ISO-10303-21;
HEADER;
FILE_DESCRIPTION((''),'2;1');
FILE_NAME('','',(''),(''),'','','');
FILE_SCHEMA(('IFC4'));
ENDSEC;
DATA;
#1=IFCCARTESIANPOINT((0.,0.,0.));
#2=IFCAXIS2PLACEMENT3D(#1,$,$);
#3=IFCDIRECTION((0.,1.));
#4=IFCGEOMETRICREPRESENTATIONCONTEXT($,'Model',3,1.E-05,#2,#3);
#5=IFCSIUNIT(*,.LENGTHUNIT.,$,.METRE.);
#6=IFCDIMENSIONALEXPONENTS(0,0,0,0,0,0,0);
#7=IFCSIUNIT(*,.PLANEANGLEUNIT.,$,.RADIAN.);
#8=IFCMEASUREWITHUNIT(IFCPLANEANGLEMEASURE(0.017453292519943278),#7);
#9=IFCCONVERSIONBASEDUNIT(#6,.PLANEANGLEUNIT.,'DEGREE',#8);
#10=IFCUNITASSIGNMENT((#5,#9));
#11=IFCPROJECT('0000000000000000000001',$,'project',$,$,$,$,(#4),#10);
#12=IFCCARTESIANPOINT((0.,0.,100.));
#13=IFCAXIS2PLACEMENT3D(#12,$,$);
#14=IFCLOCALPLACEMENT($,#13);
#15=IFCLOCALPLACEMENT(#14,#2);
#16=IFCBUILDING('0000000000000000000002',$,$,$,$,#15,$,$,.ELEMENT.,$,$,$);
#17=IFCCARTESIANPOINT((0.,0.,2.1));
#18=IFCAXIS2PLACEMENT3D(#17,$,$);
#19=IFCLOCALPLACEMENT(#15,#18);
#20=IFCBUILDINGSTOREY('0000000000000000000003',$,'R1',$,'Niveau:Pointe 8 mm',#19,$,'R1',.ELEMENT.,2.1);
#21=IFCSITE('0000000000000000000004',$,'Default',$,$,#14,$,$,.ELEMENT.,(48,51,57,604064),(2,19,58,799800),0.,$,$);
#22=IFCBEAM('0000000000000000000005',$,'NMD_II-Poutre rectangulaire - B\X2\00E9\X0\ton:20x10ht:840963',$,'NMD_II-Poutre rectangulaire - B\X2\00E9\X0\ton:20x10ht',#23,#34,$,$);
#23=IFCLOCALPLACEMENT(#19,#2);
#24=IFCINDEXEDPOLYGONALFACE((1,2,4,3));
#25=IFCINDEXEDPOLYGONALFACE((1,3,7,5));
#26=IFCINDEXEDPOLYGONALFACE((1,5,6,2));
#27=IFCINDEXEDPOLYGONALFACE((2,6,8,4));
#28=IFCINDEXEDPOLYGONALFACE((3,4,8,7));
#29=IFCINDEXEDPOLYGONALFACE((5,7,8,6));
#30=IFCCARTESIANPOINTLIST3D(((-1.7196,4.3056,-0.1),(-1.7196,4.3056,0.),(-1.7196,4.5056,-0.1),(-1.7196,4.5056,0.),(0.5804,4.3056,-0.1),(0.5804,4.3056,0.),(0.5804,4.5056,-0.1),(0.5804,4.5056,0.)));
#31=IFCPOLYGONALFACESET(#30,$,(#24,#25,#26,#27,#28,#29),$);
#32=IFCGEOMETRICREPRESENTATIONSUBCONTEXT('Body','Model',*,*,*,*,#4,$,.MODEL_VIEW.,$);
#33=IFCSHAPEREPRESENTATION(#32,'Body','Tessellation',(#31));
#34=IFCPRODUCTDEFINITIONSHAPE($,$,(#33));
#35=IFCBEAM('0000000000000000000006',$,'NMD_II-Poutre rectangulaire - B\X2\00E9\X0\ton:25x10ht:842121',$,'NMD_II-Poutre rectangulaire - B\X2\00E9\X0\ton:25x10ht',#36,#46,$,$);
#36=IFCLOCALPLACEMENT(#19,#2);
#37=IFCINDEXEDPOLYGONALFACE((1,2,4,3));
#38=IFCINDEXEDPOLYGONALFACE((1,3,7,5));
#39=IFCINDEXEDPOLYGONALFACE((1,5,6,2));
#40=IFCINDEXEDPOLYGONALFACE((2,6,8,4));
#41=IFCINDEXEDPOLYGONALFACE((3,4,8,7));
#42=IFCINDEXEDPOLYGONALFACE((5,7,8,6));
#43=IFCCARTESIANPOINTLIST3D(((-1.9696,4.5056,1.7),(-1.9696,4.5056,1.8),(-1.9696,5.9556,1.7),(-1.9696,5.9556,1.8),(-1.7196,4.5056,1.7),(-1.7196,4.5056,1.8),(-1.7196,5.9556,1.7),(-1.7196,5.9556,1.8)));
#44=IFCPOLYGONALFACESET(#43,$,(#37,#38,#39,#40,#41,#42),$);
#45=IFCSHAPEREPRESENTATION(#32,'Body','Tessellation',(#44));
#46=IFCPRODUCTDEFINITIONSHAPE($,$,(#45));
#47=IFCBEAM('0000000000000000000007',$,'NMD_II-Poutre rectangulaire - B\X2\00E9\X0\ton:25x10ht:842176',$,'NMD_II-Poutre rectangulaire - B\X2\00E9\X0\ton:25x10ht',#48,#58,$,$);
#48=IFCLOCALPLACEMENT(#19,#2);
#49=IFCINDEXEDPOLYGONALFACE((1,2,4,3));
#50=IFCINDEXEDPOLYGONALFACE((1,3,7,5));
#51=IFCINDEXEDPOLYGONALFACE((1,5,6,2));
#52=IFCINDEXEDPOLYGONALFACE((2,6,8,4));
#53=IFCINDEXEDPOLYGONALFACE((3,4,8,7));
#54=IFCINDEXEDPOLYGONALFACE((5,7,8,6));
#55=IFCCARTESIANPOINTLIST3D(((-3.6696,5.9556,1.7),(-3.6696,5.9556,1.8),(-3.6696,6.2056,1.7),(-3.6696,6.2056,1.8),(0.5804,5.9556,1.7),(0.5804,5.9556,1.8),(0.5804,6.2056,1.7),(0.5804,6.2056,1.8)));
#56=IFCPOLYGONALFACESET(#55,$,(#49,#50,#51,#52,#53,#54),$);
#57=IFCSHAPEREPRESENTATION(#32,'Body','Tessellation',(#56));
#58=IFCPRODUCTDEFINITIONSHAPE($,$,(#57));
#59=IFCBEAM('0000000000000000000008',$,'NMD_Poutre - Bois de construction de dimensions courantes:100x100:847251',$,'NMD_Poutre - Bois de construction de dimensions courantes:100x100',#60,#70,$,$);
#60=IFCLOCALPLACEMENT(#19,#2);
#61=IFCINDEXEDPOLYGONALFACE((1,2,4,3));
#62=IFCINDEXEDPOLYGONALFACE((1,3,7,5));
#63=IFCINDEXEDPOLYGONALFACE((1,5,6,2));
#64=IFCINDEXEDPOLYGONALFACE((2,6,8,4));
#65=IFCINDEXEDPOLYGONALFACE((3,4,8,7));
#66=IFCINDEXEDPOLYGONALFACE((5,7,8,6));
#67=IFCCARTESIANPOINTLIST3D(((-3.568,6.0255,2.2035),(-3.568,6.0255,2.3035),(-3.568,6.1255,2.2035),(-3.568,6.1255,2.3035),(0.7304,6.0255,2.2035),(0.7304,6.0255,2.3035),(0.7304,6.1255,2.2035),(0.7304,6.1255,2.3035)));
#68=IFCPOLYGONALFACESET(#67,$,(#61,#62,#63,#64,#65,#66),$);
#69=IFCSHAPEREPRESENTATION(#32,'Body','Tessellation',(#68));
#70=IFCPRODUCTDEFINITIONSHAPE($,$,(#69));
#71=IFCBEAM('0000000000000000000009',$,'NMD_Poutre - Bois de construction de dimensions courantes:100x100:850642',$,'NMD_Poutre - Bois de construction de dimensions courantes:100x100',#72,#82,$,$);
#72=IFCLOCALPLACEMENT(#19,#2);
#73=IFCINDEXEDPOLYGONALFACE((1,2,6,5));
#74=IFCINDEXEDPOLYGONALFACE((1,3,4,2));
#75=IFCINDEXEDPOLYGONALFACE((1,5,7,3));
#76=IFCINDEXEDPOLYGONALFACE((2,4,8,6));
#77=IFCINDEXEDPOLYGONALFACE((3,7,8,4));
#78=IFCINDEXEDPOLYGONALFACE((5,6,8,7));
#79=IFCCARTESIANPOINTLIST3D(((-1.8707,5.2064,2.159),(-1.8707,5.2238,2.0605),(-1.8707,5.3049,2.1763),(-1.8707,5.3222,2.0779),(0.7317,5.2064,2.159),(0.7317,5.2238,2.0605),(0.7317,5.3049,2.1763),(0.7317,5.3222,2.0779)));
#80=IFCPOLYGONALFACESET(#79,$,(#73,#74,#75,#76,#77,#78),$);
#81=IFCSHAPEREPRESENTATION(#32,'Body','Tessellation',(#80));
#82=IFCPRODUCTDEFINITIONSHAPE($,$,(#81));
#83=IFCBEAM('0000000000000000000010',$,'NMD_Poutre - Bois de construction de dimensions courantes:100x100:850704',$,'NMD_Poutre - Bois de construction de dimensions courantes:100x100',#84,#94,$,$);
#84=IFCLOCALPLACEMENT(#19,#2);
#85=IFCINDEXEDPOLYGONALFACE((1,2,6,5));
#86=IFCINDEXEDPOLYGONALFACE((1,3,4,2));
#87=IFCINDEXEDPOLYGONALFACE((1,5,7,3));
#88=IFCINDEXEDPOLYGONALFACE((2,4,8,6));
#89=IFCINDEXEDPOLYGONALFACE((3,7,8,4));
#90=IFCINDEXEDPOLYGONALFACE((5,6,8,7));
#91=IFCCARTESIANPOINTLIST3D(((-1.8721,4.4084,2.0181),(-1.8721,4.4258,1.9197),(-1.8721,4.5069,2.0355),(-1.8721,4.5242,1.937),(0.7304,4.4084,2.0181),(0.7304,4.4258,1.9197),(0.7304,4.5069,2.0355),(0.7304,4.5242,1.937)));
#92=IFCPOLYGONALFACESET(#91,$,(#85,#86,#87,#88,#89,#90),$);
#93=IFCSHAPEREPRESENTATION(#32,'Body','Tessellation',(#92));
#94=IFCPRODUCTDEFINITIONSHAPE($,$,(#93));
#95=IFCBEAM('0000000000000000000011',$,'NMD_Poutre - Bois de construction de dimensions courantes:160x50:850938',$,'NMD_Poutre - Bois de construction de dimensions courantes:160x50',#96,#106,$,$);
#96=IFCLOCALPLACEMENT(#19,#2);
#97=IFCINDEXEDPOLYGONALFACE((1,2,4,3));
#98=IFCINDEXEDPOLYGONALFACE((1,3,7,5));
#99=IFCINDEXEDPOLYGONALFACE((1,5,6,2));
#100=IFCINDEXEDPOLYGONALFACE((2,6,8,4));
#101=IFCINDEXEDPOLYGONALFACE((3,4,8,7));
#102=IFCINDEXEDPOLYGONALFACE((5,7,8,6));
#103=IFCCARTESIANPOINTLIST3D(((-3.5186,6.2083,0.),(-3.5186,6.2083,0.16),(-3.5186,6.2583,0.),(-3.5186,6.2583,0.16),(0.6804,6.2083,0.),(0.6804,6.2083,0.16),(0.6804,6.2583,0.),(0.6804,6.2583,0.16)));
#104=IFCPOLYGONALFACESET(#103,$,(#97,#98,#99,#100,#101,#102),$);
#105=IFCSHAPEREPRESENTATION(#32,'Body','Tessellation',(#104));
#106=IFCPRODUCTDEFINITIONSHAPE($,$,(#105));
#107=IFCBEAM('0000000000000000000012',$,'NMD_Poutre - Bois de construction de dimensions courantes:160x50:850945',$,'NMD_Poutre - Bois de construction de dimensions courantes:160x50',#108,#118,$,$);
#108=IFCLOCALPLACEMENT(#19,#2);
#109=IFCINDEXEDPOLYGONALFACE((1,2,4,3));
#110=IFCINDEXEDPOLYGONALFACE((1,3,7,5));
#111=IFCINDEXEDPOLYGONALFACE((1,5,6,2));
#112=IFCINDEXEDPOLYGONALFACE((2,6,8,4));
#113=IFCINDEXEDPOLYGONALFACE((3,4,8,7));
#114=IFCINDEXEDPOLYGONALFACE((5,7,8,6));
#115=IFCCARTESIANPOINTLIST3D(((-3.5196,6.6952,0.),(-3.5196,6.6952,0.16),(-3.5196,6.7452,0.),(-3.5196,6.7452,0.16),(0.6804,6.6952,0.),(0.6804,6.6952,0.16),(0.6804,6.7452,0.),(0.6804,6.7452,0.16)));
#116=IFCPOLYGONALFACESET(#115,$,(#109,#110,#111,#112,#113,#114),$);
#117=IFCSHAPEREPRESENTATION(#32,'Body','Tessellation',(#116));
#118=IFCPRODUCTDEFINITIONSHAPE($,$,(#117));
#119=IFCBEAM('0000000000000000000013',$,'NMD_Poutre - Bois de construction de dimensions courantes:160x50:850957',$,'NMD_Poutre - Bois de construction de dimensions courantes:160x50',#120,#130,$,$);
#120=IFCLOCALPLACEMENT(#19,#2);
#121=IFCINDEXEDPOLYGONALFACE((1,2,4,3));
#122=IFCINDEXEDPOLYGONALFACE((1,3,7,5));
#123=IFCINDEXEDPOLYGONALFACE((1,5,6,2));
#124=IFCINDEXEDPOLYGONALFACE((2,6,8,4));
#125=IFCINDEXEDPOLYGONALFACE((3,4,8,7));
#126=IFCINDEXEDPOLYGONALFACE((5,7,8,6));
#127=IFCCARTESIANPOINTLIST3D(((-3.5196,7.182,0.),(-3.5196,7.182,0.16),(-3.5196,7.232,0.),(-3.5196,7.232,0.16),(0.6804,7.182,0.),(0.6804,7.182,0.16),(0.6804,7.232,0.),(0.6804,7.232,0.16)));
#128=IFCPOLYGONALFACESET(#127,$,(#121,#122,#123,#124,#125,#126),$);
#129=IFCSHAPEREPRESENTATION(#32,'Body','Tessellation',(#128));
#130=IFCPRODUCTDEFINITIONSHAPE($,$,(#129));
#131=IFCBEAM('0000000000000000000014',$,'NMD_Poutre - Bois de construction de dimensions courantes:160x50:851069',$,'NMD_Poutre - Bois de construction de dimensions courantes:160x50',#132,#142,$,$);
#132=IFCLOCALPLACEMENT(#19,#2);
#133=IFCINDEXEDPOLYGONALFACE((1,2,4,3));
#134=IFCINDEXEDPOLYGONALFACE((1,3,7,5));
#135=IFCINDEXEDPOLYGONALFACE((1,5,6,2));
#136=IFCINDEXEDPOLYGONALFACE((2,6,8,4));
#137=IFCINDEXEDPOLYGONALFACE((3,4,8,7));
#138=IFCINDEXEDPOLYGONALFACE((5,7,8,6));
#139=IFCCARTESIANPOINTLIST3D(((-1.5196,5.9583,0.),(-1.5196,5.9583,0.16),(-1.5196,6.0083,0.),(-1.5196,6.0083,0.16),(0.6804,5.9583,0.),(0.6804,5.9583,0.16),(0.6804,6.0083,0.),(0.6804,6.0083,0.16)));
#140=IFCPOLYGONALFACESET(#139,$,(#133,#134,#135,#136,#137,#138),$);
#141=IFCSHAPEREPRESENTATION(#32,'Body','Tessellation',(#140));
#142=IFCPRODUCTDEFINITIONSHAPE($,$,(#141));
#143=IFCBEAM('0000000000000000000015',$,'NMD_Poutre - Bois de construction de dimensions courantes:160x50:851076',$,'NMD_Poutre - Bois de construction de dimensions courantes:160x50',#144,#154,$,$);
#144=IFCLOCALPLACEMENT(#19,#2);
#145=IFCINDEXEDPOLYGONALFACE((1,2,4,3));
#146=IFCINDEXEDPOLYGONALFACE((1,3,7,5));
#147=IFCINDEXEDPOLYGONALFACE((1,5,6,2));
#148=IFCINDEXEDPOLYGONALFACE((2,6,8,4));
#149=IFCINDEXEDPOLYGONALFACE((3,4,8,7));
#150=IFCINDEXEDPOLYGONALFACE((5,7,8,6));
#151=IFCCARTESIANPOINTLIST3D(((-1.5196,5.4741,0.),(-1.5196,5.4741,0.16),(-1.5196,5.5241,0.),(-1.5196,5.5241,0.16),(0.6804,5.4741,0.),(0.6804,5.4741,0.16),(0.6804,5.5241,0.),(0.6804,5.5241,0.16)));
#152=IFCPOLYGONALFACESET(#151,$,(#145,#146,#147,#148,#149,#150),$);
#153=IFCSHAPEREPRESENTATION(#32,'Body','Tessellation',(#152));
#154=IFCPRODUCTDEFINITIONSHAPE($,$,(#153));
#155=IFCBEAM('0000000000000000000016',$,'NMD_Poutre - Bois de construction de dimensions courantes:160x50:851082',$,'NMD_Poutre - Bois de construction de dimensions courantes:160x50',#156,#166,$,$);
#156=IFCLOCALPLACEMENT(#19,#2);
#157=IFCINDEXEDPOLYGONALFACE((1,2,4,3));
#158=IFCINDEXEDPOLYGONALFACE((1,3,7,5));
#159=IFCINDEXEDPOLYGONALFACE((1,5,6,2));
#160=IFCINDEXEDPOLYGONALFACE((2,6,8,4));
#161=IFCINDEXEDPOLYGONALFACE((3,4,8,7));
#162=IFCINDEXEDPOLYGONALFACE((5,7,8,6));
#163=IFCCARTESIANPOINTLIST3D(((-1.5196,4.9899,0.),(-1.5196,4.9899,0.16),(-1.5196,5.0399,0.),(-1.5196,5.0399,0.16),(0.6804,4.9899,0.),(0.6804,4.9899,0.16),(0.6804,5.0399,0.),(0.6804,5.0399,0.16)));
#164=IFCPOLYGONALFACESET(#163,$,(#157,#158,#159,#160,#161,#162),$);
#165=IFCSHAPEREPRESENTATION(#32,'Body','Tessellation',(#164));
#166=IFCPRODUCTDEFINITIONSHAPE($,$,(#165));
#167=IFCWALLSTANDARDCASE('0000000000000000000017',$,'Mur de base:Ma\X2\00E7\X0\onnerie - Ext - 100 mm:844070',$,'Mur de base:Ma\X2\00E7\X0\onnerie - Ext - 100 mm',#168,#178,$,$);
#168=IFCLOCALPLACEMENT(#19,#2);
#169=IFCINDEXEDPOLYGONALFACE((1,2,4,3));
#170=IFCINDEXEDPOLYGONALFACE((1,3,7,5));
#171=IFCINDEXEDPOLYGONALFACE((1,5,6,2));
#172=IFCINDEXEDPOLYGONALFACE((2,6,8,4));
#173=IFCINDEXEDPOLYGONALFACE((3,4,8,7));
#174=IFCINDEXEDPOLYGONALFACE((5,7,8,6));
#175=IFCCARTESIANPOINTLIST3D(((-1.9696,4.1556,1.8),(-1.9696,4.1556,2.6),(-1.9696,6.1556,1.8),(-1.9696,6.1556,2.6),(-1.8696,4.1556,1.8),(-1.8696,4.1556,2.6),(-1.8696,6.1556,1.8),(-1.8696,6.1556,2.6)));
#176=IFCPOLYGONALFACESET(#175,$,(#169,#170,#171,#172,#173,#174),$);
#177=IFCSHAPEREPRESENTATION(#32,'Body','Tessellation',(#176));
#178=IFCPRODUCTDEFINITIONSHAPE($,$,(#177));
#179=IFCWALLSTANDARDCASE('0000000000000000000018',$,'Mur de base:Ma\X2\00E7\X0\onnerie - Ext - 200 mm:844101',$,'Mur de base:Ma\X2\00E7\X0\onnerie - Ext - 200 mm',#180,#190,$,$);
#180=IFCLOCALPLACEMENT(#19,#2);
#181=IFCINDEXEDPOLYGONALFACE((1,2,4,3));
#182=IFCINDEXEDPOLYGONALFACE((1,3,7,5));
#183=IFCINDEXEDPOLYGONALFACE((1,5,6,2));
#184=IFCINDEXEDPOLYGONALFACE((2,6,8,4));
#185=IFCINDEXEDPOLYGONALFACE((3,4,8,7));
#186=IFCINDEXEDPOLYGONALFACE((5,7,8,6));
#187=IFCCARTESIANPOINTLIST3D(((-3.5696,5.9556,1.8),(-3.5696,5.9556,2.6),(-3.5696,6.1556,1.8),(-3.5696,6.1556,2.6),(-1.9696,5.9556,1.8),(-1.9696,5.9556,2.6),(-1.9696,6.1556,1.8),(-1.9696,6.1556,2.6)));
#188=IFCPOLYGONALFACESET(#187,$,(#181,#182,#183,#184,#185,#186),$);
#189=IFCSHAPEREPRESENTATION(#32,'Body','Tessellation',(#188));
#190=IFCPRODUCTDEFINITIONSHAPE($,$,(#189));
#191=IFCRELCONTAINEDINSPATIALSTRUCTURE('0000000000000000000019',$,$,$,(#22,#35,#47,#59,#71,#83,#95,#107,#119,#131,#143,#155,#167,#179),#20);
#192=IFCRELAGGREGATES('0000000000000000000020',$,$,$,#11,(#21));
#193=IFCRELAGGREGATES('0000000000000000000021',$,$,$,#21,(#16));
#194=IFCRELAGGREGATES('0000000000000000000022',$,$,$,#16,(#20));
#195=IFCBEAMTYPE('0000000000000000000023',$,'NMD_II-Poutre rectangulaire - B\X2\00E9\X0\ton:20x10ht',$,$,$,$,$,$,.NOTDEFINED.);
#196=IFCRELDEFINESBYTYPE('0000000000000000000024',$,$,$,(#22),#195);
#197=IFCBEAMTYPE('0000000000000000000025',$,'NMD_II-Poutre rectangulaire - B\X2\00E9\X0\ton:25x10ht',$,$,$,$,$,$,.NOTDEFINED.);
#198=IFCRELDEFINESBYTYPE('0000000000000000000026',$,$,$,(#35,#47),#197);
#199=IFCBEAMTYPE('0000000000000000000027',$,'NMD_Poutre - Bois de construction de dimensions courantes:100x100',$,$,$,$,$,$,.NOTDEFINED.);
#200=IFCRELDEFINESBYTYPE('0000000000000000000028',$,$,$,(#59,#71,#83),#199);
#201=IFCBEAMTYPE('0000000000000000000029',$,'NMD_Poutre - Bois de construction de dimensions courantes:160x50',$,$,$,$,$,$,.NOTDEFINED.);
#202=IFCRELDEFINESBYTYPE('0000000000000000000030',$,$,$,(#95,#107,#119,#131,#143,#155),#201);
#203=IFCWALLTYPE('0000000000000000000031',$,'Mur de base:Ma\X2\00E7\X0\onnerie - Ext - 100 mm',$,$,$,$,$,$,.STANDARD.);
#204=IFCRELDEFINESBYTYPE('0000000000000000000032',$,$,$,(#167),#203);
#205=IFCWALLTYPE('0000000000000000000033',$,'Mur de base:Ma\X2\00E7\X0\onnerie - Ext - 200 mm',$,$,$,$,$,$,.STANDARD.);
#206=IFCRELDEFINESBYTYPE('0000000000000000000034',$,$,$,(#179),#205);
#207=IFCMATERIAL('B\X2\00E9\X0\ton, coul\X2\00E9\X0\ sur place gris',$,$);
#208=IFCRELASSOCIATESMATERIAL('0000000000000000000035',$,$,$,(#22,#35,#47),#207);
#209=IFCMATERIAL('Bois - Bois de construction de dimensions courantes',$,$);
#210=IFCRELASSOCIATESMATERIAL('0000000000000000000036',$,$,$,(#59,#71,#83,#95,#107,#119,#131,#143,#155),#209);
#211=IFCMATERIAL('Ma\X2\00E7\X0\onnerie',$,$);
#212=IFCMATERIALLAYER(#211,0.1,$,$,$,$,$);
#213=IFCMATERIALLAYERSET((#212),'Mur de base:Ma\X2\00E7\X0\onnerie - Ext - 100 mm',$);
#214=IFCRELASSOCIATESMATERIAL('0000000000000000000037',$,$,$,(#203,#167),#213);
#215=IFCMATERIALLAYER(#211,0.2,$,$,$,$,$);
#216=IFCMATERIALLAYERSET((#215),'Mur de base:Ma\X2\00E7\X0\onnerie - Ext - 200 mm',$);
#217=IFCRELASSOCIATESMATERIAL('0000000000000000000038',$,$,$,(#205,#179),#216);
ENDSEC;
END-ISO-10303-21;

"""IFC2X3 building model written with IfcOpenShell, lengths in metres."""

from ifc_helpers import new_model, entity, si_unit, converted_unit, direction, frame, frame_2d, origin, place, context, subcontext, project, spatial, rectangle, extrude, material, layer, layer_set, layer_usage, type_object, element, save


model = new_model("IFC2X3")

# Units and contexts
model_context = context("Model", 3, precision=1e-05, world=origin(), true_north=direction((0.0, 1.0)))
body_context = subcontext(model_context, "Body", "Model", "MODEL_VIEW")
ifc_project = project(units=[si_unit("LENGTHUNIT", "METRE"), converted_unit("PLANEANGLEUNIT", "DEGREE", entity("IfcPlaneAngleMeasure", 0.017453292519943278), si_unit("PLANEANGLEUNIT", "RADIAN"), dimensions=[0, 0, 0, 0, 0, 0, 0])], contexts=[model_context])

# Site, building, storey
site_placement = place(None, frame((0.0, 0.0, 100.0)))
site = spatial("IfcSite", under=ifc_project, at=site_placement, Name="Default", CompositionType="ELEMENT", RefLatitude=(48, 51, 57, 604064), RefLongitude=(2, 19, 58, 799800), RefElevation=0.0)
building_placement = place(site_placement, origin())
building = spatial("IfcBuilding", under=site, at=building_placement, CompositionType="ELEMENT")
storey_placement = place(building_placement, frame((0.0, 0.0, 2.1)))
storey = spatial("IfcBuildingStorey", under=building, at=storey_placement, Name="R1", ObjectType="Niveau:Pointe 8 mm", LongName="R1", CompositionType="ELEMENT", Elevation=2.1)

# Beams
ifc_material_1 = material(Name="Béton, coulé sur place gris")
beam_type_1 = type_object("IfcBeamType", Name="NMD_II-Poutre rectangulaire - Béton:20x10ht", PredefinedType="NOTDEFINED")
beam_1_placement = place(storey_placement, frame((0.5804, 4.4056, 0.0), z_axis=(0.0, 0.0, 1.0), x_axis=(-1.0, 0.0, 0.0)))
element("IfcBeam", 1, at=beam_1_placement, inside=storey, type_object=beam_type_1, material=ifc_material_1, Name="NMD_II-Poutre rectangulaire - Béton:20x10ht:840963", ObjectType="NMD_II-Poutre rectangulaire - Béton:20x10ht", context=body_context, shape_type="SweptSolid", body=[
    extrude(rectangle(XDim=0.1, YDim=0.2, at=frame_2d((0.0, 0.0), x_axis=(1.0, 0.0))), frame((0.0, 0.0, -0.05), z_axis=(1.0, 0.0, 0.0), x_axis=(0.0, 0.0, -1.0)), (0.0, 0.0, 1.0), 2.3),
])
beam_type_2 = type_object("IfcBeamType", Name="NMD_II-Poutre rectangulaire - Béton:25x10ht", PredefinedType="NOTDEFINED")
beam_2_placement = place(storey_placement, frame((-1.8446, 6.0806, 1.8), z_axis=(0.0, 0.0, 1.0), x_axis=(0.0, -1.0, 0.0)))
element("IfcBeam", 2, at=beam_2_placement, inside=storey, type_object=beam_type_2, material=ifc_material_1, Name="NMD_II-Poutre rectangulaire - Béton:25x10ht:842121", ObjectType="NMD_II-Poutre rectangulaire - Béton:25x10ht", context=body_context, shape_type="SweptSolid", body=[
    extrude(rectangle(XDim=0.1, YDim=0.25, at=frame_2d((0.0, 0.0), x_axis=(1.0, 0.0))), frame((0.125, 0.0, -0.05), z_axis=(1.0, 0.0, 0.0), x_axis=(0.0, 0.0, -1.0)), (0.0, 0.0, 1.0), 1.45),
])
beam_3_placement = place(storey_placement, frame((0.7054, 6.0806, 1.8), z_axis=(0.0, 0.0, 1.0), x_axis=(-1.0, 0.0, 0.0)))
element("IfcBeam", 3, at=beam_3_placement, inside=storey, type_object=beam_type_2, material=ifc_material_1, Name="NMD_II-Poutre rectangulaire - Béton:25x10ht:842176", ObjectType="NMD_II-Poutre rectangulaire - Béton:25x10ht", context=body_context, shape_type="SweptSolid", body=[
    extrude(rectangle(XDim=0.1, YDim=0.25, at=frame_2d((0.0, 0.0), x_axis=(1.0, 0.0))), frame((0.125, 0.0, -0.05), z_axis=(1.0, 0.0, 0.0), x_axis=(0.0, 0.0, -1.0)), (0.0, 0.0, 1.0), 4.25),
])
ifc_material_2 = material(Name="Bois - Bois de construction de dimensions courantes")
beam_type_3 = type_object("IfcBeamType", Name="NMD_Poutre - Bois de construction de dimensions courantes:100x100", PredefinedType="NOTDEFINED")
beam_4_placement = place(storey_placement, frame((-3.5685, 6.0755, 2.3035)))
element("IfcBeam", 4, at=beam_4_placement, inside=storey, type_object=beam_type_3, material=ifc_material_2, Name="NMD_Poutre - Bois de construction de dimensions courantes:100x100:847251", ObjectType="NMD_Poutre - Bois de construction de dimensions courantes:100x100", context=body_context, shape_type="SweptSolid", body=[
    extrude(rectangle(XDim=0.1, YDim=0.1, at=frame_2d((0.0, 0.0), x_axis=(1.0, 0.0))), frame((0.0004, 0.0, -0.05), z_axis=(1.0, 0.0, 0.0), x_axis=(0.0, 0.0, -1.0)), (0.0, 0.0, 1.0), 4.2984),
])
beam_5_placement = place(storey_placement, frame((-1.9196, 5.2556, 2.1676)))
element("IfcBeam", 5, at=beam_5_placement, inside=storey, type_object=beam_type_3, material=ifc_material_2, Name="NMD_Poutre - Bois de construction de dimensions courantes:100x100:850642", ObjectType="NMD_Poutre - Bois de construction de dimensions courantes:100x100", context=body_context, shape_type="SweptSolid", body=[
    extrude(rectangle(XDim=0.1, YDim=0.1, at=frame_2d((0.0, 0.0), x_axis=(0.0, 1.0))), frame((0.0489, 0.0087, -0.0492), z_axis=(1.0, 0.0, 0.0), x_axis=(0.0, -0.984777, -0.17382)), (0.0, 0.0, 1.0), 2.6024),
])
beam_6_placement = place(storey_placement, frame((-1.8196, 4.4576, 2.0268)))
element("IfcBeam", 6, at=beam_6_placement, inside=storey, type_object=beam_type_3, material=ifc_material_2, Name="NMD_Poutre - Bois de construction de dimensions courantes:100x100:850704", ObjectType="NMD_Poutre - Bois de construction de dimensions courantes:100x100", context=body_context, shape_type="SweptSolid", body=[
    extrude(rectangle(XDim=0.1, YDim=0.1, at=frame_2d((0.0, 0.0), x_axis=(0.0, 1.0))), frame((-0.0525, 0.0087, -0.0492), z_axis=(1.0, 0.0, 0.0), x_axis=(0.0, -0.984777, -0.17382)), (0.0, 0.0, 1.0), 2.6025),
])
beam_type_4 = type_object("IfcBeamType", Name="NMD_Poutre - Bois de construction de dimensions courantes:160x50", PredefinedType="NOTDEFINED")
beam_7_placement = place(storey_placement, frame((-3.5196, 6.2333, 0.16)))
element("IfcBeam", 7, at=beam_7_placement, inside=storey, type_object=beam_type_4, material=ifc_material_2, Name="NMD_Poutre - Bois de construction de dimensions courantes:160x50:850938", ObjectType="NMD_Poutre - Bois de construction de dimensions courantes:160x50", context=body_context, shape_type="SweptSolid", body=[
    extrude(rectangle(XDim=0.16, YDim=0.05, at=frame_2d((0.0, 0.0), x_axis=(1.0, 0.0))), frame((0.001, 0.0, -0.08), z_axis=(1.0, 0.0, 0.0), x_axis=(0.0, 0.0, -1.0)), (0.0, 0.0, 1.0), 4.199),
])
for number, where, name in (
    (8, (-3.5196, 6.7202, 0.16), "NMD_Poutre - Bois de construction de dimensions courantes:160x50:850945"),
    (9, (-3.5196, 7.207, 0.16), "NMD_Poutre - Bois de construction de dimensions courantes:160x50:850957"),
):
    element("IfcBeam", number, at=place(storey_placement, frame(where)), inside=storey, type_object=beam_type_4, material=ifc_material_2, Name=name, ObjectType="NMD_Poutre - Bois de construction de dimensions courantes:160x50", context=body_context, shape_type="SweptSolid", body=[
        extrude(rectangle(XDim=0.16, YDim=0.05, at=frame_2d((0.0, 0.0), x_axis=(1.0, 0.0))), frame((0.0, 0.0, -0.08), z_axis=(1.0, 0.0, 0.0), x_axis=(0.0, 0.0, -1.0)), (0.0, 0.0, 1.0), 4.2),
    ])
for number, where, name in (
    (10, (-1.5196, 5.9833, 0.16), "NMD_Poutre - Bois de construction de dimensions courantes:160x50:851069"),
    (11, (-1.5196, 5.4991, 0.16), "NMD_Poutre - Bois de construction de dimensions courantes:160x50:851076"),
    (12, (-1.5196, 5.0149, 0.16), "NMD_Poutre - Bois de construction de dimensions courantes:160x50:851082"),
):
    element("IfcBeam", number, at=place(storey_placement, frame(where)), inside=storey, type_object=beam_type_4, material=ifc_material_2, Name=name, ObjectType="NMD_Poutre - Bois de construction de dimensions courantes:160x50", context=body_context, shape_type="SweptSolid", body=[
        extrude(rectangle(XDim=0.16, YDim=0.05, at=frame_2d((0.0, 0.0), x_axis=(1.0, 0.0))), frame((0.0, 0.0, -0.08), z_axis=(1.0, 0.0, 0.0), x_axis=(0.0, 0.0, -1.0)), (0.0, 0.0, 1.0), 2.2),
    ])

# Walls
ifc_material_3 = material(Name="Maçonnerie")
ifc_layer_1 = layer(ifc_material_3, 0.1)
ifc_layer_set_1 = layer_set([ifc_layer_1], Name="Mur de base:Maçonnerie - Ext - 100 mm")
ifc_layer_usage_1 = layer_usage(ifc_layer_set_1, "AXIS2", "NEGATIVE", 0.05)
wall_type_1 = type_object("IfcWallType", Name="Mur de base:Maçonnerie - Ext - 100 mm", PredefinedType="STANDARD", material=ifc_layer_set_1)
wall_1_placement = place(storey_placement, frame((-1.9196, 6.1556, 1.8), z_axis=(0.0, 0.0, 1.0), x_axis=(0.0, -1.0, 0.0)))
element("IfcWallStandardCase", 13, at=wall_1_placement, inside=storey, type_object=wall_type_1, material=ifc_layer_usage_1, Name="Mur de base:Maçonnerie - Ext - 100 mm:844070", ObjectType="Mur de base:Maçonnerie - Ext - 100 mm", context=body_context, shape_type="SweptSolid", body=[
    extrude(rectangle(XDim=2.0, YDim=0.1, at=frame_2d((1.0, 0.0), x_axis=(-1.0, 0.0))), origin(), (0.0, 0.0, 1.0), 0.8),
])
ifc_layer_2 = layer(ifc_material_3, 0.2)
ifc_layer_set_2 = layer_set([ifc_layer_2], Name="Mur de base:Maçonnerie - Ext - 200 mm")
ifc_layer_usage_2 = layer_usage(ifc_layer_set_2, "AXIS2", "NEGATIVE", 0.1)
wall_type_2 = type_object("IfcWallType", Name="Mur de base:Maçonnerie - Ext - 200 mm", PredefinedType="STANDARD", material=ifc_layer_set_2)
wall_2_placement = place(storey_placement, frame((-3.5696, 6.0556, 1.8)))
element("IfcWallStandardCase", 14, at=wall_2_placement, inside=storey, type_object=wall_type_2, material=ifc_layer_usage_2, Name="Mur de base:Maçonnerie - Ext - 200 mm:844101", ObjectType="Mur de base:Maçonnerie - Ext - 200 mm", context=body_context, shape_type="SweptSolid", body=[
    extrude(rectangle(XDim=1.6, YDim=0.2, at=frame_2d((0.8, 0.0), x_axis=(-1.0, 0.0))), origin(), (0.0, 0.0, 1.0), 0.8),
])

save(model, "model.ifc")
